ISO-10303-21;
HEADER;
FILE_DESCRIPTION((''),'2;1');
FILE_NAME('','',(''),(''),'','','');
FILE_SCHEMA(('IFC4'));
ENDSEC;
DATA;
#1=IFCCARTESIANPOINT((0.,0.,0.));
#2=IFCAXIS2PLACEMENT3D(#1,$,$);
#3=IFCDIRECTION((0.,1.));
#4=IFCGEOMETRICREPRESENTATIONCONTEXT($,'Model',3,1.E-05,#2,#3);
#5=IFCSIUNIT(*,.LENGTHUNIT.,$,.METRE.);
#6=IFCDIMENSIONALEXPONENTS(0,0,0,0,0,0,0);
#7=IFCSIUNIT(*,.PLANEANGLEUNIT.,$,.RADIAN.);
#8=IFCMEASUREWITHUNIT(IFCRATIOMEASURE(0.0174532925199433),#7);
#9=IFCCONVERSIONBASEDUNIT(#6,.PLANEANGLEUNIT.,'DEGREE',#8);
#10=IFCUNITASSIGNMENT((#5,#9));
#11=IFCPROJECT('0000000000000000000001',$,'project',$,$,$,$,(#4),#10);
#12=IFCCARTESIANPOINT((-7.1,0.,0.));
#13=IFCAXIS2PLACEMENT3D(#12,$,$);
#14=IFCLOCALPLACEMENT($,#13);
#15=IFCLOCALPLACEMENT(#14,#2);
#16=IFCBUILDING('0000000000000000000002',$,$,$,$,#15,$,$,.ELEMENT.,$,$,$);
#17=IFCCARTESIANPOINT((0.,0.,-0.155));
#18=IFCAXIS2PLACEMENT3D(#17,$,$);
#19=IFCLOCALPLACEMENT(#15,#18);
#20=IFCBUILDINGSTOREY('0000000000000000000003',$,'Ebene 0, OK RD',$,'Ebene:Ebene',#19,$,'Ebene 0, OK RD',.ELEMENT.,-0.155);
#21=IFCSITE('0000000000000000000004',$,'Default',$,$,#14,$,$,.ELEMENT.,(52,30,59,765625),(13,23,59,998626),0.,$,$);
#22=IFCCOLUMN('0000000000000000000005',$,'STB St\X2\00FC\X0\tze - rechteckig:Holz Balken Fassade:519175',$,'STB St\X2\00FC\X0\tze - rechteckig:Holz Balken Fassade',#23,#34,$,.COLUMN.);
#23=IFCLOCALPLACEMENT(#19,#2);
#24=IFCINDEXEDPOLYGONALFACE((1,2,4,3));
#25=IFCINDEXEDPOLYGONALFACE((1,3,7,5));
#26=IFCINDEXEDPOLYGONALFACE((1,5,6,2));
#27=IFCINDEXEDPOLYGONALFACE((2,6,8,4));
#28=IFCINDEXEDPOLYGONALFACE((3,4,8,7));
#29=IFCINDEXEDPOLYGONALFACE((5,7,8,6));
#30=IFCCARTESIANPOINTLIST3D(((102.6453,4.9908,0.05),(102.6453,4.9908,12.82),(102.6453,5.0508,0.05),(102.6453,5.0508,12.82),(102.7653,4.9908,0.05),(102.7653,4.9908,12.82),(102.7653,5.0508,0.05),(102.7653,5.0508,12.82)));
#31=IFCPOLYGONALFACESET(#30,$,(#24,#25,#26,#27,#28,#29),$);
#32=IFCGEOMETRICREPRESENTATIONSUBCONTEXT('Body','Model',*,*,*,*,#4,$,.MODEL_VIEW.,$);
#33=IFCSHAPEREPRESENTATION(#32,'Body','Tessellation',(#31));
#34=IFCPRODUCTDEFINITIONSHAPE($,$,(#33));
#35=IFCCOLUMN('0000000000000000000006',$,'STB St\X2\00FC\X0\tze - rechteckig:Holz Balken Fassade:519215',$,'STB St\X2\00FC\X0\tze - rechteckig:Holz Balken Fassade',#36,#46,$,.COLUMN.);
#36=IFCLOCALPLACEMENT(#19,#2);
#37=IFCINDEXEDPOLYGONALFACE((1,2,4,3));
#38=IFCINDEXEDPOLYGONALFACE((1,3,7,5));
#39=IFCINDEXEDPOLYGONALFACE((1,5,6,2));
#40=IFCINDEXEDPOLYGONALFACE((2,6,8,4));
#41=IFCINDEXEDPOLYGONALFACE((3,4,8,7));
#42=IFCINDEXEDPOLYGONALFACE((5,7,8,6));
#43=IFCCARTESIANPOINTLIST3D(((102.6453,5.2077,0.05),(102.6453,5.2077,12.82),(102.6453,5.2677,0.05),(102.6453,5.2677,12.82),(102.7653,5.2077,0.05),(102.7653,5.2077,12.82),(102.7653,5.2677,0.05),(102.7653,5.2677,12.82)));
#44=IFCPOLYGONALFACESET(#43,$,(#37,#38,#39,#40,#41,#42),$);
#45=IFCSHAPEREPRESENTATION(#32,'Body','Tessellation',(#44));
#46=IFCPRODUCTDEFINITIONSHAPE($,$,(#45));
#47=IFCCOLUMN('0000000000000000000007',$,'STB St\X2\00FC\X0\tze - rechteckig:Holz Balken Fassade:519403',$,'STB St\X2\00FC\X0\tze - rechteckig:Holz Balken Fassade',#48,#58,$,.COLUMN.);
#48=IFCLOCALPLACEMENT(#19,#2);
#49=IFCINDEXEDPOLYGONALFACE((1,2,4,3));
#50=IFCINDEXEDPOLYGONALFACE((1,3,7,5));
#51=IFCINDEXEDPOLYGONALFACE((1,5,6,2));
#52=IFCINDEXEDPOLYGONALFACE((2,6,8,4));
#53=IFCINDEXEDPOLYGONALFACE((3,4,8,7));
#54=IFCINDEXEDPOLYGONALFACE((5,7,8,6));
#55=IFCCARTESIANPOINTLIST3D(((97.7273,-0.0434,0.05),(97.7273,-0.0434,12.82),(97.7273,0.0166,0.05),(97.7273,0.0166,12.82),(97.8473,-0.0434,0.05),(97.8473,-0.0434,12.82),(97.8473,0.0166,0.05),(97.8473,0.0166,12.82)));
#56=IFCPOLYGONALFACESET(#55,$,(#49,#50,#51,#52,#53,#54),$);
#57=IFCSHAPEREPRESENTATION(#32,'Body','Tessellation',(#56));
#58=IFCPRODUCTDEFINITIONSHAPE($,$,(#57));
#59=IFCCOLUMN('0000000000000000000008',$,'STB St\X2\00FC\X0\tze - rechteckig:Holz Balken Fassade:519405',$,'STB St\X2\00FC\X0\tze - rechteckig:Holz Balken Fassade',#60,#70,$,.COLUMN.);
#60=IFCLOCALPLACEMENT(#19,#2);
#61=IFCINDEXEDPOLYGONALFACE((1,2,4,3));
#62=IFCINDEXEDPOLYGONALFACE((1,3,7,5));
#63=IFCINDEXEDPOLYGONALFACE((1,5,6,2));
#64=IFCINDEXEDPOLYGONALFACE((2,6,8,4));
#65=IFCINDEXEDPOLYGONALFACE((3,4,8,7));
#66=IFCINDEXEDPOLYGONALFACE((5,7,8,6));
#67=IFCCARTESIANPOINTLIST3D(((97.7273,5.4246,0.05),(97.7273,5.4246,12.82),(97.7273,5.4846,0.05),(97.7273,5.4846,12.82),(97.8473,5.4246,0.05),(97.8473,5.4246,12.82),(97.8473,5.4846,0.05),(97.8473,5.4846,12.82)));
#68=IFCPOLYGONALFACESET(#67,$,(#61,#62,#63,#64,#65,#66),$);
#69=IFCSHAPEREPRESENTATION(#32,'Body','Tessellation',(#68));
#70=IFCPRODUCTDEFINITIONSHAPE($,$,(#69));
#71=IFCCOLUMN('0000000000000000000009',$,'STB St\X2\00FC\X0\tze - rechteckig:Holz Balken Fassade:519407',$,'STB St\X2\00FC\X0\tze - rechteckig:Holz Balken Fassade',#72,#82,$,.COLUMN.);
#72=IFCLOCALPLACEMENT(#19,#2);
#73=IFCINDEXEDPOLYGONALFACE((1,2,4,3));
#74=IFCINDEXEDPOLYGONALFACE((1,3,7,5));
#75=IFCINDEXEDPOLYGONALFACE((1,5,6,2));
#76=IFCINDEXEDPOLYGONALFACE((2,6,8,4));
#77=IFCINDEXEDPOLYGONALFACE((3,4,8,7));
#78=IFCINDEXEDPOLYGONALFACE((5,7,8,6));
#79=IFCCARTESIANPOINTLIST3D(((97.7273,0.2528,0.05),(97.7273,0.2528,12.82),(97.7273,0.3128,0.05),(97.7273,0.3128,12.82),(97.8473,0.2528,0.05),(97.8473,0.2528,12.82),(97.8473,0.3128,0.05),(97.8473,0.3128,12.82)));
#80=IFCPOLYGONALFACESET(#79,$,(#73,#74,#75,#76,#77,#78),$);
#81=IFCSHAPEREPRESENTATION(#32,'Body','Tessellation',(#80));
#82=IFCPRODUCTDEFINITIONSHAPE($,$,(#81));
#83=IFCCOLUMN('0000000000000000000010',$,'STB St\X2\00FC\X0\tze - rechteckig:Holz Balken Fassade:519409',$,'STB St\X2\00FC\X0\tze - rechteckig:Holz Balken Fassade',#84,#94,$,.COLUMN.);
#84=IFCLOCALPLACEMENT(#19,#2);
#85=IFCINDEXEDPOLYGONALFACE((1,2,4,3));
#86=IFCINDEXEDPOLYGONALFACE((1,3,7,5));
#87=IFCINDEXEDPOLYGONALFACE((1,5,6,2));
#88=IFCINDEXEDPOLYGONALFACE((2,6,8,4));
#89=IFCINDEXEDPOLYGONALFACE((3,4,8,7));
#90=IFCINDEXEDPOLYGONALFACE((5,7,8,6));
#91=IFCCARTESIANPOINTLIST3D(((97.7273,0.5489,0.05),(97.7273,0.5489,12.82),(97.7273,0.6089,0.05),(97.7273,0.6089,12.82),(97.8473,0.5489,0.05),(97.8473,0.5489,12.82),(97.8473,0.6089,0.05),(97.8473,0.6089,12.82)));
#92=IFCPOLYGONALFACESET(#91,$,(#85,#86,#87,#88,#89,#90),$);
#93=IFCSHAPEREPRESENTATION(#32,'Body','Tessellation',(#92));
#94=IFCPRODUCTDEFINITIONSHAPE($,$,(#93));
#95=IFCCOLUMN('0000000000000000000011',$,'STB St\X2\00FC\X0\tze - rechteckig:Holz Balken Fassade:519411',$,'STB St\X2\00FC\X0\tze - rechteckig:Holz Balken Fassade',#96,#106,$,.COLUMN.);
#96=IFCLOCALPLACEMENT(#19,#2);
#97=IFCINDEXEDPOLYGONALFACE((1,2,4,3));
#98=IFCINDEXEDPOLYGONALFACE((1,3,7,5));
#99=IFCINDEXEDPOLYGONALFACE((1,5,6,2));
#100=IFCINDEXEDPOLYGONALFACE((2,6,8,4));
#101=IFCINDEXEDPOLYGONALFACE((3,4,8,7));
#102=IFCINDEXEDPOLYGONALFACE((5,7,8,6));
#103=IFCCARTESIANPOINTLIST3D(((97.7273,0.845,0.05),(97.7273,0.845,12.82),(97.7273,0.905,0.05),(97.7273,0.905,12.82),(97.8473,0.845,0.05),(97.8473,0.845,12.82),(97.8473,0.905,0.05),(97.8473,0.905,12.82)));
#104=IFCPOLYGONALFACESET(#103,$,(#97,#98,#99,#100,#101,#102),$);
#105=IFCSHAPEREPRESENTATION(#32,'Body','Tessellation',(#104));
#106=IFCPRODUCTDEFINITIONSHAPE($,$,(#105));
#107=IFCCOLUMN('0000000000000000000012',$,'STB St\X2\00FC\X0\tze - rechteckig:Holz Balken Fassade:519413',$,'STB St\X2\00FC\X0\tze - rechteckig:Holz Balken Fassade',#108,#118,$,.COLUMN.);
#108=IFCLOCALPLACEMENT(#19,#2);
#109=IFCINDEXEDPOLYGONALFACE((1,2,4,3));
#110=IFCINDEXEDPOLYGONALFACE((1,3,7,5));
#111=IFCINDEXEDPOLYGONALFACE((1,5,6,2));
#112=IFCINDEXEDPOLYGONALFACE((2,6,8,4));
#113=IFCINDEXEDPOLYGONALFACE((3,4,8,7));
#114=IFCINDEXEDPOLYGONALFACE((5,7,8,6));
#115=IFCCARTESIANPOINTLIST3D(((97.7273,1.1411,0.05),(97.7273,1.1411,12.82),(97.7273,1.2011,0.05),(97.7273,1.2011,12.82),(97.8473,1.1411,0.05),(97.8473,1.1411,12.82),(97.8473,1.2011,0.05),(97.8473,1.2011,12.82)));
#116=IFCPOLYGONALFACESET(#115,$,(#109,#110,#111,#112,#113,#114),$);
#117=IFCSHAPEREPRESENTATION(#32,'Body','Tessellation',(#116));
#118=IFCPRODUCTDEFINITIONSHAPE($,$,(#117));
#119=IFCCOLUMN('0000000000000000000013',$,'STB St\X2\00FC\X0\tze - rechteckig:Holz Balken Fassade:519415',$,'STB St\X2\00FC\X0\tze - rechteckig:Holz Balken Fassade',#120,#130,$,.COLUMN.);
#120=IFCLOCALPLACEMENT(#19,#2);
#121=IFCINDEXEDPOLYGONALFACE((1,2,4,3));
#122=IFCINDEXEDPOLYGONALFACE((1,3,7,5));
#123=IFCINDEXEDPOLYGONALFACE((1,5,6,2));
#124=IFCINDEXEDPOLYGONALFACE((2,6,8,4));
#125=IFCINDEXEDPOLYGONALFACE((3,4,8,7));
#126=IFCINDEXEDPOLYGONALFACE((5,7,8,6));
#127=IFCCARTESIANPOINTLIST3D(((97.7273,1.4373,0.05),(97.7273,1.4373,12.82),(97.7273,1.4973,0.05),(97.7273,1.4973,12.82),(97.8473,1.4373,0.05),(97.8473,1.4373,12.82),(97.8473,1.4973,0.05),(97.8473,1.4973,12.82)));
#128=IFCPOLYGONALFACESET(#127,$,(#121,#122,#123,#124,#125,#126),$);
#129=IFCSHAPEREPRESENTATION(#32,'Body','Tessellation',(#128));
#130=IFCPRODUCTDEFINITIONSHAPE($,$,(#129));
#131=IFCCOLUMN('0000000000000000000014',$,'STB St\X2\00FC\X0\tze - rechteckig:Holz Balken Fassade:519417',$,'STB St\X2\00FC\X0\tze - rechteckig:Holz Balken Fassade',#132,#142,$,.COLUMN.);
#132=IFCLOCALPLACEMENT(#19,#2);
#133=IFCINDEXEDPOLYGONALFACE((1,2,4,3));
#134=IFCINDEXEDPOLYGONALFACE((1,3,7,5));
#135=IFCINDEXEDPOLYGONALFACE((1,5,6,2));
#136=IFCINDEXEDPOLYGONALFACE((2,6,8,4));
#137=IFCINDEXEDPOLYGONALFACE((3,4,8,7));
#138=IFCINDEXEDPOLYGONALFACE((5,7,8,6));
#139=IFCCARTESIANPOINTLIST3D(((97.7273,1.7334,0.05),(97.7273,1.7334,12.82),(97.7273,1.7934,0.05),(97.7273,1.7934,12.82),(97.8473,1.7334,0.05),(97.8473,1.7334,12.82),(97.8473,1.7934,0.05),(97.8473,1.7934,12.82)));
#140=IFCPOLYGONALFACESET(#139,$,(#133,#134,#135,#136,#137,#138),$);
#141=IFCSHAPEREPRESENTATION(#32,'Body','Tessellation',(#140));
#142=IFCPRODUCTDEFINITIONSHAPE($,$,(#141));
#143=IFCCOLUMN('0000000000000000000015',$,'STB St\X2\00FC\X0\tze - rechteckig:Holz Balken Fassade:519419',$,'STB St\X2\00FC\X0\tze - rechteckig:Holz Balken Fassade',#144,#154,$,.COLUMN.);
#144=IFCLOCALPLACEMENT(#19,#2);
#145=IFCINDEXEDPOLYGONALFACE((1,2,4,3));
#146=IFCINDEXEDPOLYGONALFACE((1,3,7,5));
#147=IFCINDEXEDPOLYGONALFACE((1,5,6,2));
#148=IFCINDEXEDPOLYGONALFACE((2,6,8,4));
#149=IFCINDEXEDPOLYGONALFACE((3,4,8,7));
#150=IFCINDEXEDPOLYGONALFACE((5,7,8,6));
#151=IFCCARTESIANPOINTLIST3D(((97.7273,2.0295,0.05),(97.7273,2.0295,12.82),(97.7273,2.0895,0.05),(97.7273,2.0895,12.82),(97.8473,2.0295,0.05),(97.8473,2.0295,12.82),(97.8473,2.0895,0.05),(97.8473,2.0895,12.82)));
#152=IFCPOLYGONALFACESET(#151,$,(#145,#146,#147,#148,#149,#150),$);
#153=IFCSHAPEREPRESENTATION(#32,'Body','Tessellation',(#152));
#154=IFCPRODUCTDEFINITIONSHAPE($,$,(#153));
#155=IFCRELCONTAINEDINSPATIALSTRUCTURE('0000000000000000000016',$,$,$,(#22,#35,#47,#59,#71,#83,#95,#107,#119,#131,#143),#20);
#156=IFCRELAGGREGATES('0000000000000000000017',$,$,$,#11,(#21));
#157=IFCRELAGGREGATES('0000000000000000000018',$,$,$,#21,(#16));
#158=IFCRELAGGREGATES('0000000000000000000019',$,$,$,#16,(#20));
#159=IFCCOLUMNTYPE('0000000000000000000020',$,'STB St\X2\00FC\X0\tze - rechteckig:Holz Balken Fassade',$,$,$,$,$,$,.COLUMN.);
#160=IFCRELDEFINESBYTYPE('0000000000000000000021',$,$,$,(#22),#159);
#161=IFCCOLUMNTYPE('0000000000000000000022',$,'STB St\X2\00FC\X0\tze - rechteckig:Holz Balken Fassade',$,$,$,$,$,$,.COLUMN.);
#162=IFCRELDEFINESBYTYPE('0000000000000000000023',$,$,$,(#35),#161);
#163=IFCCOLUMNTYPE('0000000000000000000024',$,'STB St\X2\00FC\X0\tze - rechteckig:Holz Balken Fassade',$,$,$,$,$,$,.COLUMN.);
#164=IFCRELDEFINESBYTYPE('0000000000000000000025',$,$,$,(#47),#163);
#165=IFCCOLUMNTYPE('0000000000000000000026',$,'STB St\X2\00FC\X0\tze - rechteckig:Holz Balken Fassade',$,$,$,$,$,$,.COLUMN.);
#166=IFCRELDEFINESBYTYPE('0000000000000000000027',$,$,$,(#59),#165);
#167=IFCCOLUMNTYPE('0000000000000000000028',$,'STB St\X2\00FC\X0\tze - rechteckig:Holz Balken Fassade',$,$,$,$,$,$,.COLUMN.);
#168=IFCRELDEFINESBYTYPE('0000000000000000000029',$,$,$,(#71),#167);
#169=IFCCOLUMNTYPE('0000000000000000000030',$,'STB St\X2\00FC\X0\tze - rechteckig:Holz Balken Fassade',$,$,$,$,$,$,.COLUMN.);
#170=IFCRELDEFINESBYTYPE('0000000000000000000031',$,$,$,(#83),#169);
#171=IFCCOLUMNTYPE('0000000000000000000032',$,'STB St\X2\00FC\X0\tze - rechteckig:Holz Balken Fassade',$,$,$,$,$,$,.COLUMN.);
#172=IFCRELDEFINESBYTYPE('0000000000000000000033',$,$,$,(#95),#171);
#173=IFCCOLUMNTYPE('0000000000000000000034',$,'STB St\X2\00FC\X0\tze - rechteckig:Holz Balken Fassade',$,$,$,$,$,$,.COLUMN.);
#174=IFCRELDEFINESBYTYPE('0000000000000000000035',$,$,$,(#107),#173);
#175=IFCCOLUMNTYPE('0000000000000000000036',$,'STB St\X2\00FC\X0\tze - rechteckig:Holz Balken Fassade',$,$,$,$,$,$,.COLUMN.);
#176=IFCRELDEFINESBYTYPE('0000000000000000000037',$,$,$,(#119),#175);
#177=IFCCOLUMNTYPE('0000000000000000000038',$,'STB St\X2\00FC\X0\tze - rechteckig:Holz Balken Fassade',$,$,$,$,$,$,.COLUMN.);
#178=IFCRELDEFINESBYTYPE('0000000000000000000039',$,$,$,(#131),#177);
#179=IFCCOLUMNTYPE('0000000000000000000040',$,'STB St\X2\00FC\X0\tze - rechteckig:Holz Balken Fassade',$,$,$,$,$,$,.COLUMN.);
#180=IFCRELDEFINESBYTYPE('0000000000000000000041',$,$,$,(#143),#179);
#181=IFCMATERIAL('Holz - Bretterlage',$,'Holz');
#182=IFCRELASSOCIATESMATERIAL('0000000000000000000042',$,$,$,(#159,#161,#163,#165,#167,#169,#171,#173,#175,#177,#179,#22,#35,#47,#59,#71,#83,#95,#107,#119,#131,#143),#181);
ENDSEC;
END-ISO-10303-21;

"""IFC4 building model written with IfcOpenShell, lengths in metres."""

from ifc_helpers import new_model, entity, si_unit, converted_unit, direction, frame, frame_2d, origin, origin_2d_with_axis, place, context, subcontext, project, spatial, rectangle, extrude, source, transform, mapped, material, material_profile, profile_set, profile_usage, type_object, type_shapes, element, save


model = new_model("IFC4")

# Units and contexts
model_context = context("Model", 3, precision=1e-05, world=origin(), true_north=direction((0.0, 1.0)))
body_context = subcontext(model_context, "Body", "Model", "MODEL_VIEW")
ifc_project = project(units=[si_unit("LENGTHUNIT", "METRE"), converted_unit("PLANEANGLEUNIT", "DEGREE", entity("IfcRatioMeasure", 0.0174532925199433), si_unit("PLANEANGLEUNIT", "RADIAN"), dimensions=[0, 0, 0, 0, 0, 0, 0])], contexts=[model_context])

# Site, building, storey
site_placement = place(None, frame((-7.1, 0.0, 0.0)))
site = spatial("IfcSite", under=ifc_project, at=site_placement, Name="Default", CompositionType="ELEMENT", RefLatitude=(52, 30, 59, 765625), RefLongitude=(13, 23, 59, 998626), RefElevation=0.0)
building_placement = place(site_placement, origin())
building = spatial("IfcBuilding", under=site, at=building_placement, CompositionType="ELEMENT")
storey_placement = place(building_placement, frame((0.0, 0.0, -0.155)))
storey = spatial("IfcBuildingStorey", under=building, at=storey_placement, Name="Ebene 0, OK RD", ObjectType="Ebene:Ebene", LongName="Ebene 0, OK RD", CompositionType="ELEMENT", Elevation=-0.155)

# Columns
ifc_material_1 = material(Name="Holz - Bretterlage", Category="Holz")
ifc_material_profile = material_profile(ifc_material_1, rectangle(XDim=0.12, YDim=0.06, at=frame_2d((0.0, 0.0), x_axis=(1.0, 0.0))), Name="Holz Balken Fassade")
ifc_profile_set = profile_set([ifc_material_profile], Name="Holz Balken Fassade")
ifc_profile_usage_1 = profile_usage(ifc_profile_set)
column_type_1 = type_object("IfcColumnType", Name="STB Stütze - rechteckig:Holz Balken Fassade", PredefinedType="COLUMN", material=ifc_profile_set)
shared_shape_1 = source(origin(), body_context, "Body", "SweptSolid", [
    extrude(rectangle(XDim=0.06, YDim=0.12, at=origin_2d_with_axis()), frame((102.7053, 5.0208, -0.105), z_axis=(0.0, 0.0, 1.0), x_axis=(0.0, -1.0, 0.0)), (0.0, 0.0, 1.0), 12.77),
])
type_shapes(column_type_1, [shared_shape_1])
column_1_placement = place(storey_placement, frame((0.0, 0.0, 0.155)))
element("IfcColumn", 1, at=column_1_placement, inside=storey, type_object=column_type_1, material=ifc_profile_usage_1, Name="STB Stütze - rechteckig:Holz Balken Fassade:519175", ObjectType="STB Stütze - rechteckig:Holz Balken Fassade", PredefinedType="COLUMN", context=body_context, shape_type="MappedRepresentation", body=[
    mapped(shared_shape_1, transform((0.0, 0.0, 0.0), scale=1.0)),
])
ifc_profile_usage_2 = profile_usage(ifc_profile_set)
column_type_2 = type_object("IfcColumnType", Name="STB Stütze - rechteckig:Holz Balken Fassade", PredefinedType="COLUMN", material=ifc_profile_set)
shared_shape_2 = source(origin(), body_context, "Body", "SweptSolid", [
    extrude(rectangle(XDim=0.06, YDim=0.12, at=origin_2d_with_axis()), frame((102.7053, 5.2377, -0.105), z_axis=(0.0, 0.0, 1.0), x_axis=(0.0, -1.0, 0.0)), (0.0, 0.0, 1.0), 12.77),
])
type_shapes(column_type_2, [shared_shape_2])
column_2_placement = place(storey_placement, frame((0.0, 0.0, 0.155)))
element("IfcColumn", 2, at=column_2_placement, inside=storey, type_object=column_type_2, material=ifc_profile_usage_2, Name="STB Stütze - rechteckig:Holz Balken Fassade:519215", ObjectType="STB Stütze - rechteckig:Holz Balken Fassade", PredefinedType="COLUMN", context=body_context, shape_type="MappedRepresentation", body=[
    mapped(shared_shape_2, transform((0.0, 0.0, 0.0), scale=1.0)),
])
ifc_profile_usage_3 = profile_usage(ifc_profile_set)
column_type_3 = type_object("IfcColumnType", Name="STB Stütze - rechteckig:Holz Balken Fassade", PredefinedType="COLUMN", material=ifc_profile_set)
shared_shape_3 = source(origin(), body_context, "Body", "SweptSolid", [
    extrude(rectangle(XDim=0.06, YDim=0.12, at=frame_2d((0.0, 0.0), x_axis=(1.0, 0.0))), frame((97.7873, -0.0134, -0.105), z_axis=(0.0, 0.0, 1.0), x_axis=(0.0, -1.0, 0.0)), (0.0, 0.0, 1.0), 12.77),
])
type_shapes(column_type_3, [shared_shape_3])
column_3_placement = place(storey_placement, frame((0.0, 0.0, 0.155)))
element("IfcColumn", 3, at=column_3_placement, inside=storey, type_object=column_type_3, material=ifc_profile_usage_3, Name="STB Stütze - rechteckig:Holz Balken Fassade:519403", ObjectType="STB Stütze - rechteckig:Holz Balken Fassade", PredefinedType="COLUMN", context=body_context, shape_type="MappedRepresentation", body=[
    mapped(shared_shape_3, transform((0.0, 0.0, 0.0), scale=1.0)),
])
ifc_profile_usage_4 = profile_usage(ifc_profile_set)
column_type_4 = type_object("IfcColumnType", Name="STB Stütze - rechteckig:Holz Balken Fassade", PredefinedType="COLUMN", material=ifc_profile_set)
shared_shape_4 = source(origin(), body_context, "Body", "SweptSolid", [
    extrude(rectangle(XDim=0.06, YDim=0.12, at=origin_2d_with_axis()), frame((97.7873, 5.4546, -0.105), z_axis=(0.0, 0.0, 1.0), x_axis=(0.0, -1.0, 0.0)), (0.0, 0.0, 1.0), 12.77),
])
type_shapes(column_type_4, [shared_shape_4])
column_4_placement = place(storey_placement, frame((0.0, 0.0, 0.155)))
element("IfcColumn", 4, at=column_4_placement, inside=storey, type_object=column_type_4, material=ifc_profile_usage_4, Name="STB Stütze - rechteckig:Holz Balken Fassade:519405", ObjectType="STB Stütze - rechteckig:Holz Balken Fassade", PredefinedType="COLUMN", context=body_context, shape_type="MappedRepresentation", body=[
    mapped(shared_shape_4, transform((0.0, 0.0, 0.0), scale=1.0)),
])
ifc_profile_usage_5 = profile_usage(ifc_profile_set)
column_type_5 = type_object("IfcColumnType", Name="STB Stütze - rechteckig:Holz Balken Fassade", PredefinedType="COLUMN", material=ifc_profile_set)
shared_shape_5 = source(origin(), body_context, "Body", "SweptSolid", [
    extrude(rectangle(XDim=0.06, YDim=0.12, at=frame_2d((0.0, 0.0), x_axis=(1.0, 0.0))), frame((97.7873, 0.2828, -0.105), z_axis=(0.0, 0.0, 1.0), x_axis=(0.0, -1.0, 0.0)), (0.0, 0.0, 1.0), 12.77),
])
type_shapes(column_type_5, [shared_shape_5])
column_5_placement = place(storey_placement, frame((0.0, 0.0, 0.155)))
element("IfcColumn", 5, at=column_5_placement, inside=storey, type_object=column_type_5, material=ifc_profile_usage_5, Name="STB Stütze - rechteckig:Holz Balken Fassade:519407", ObjectType="STB Stütze - rechteckig:Holz Balken Fassade", PredefinedType="COLUMN", context=body_context, shape_type="MappedRepresentation", body=[
    mapped(shared_shape_5, transform((0.0, 0.0, 0.0), scale=1.0)),
])
ifc_profile_usage_6 = profile_usage(ifc_profile_set)
column_type_6 = type_object("IfcColumnType", Name="STB Stütze - rechteckig:Holz Balken Fassade", PredefinedType="COLUMN", material=ifc_profile_set)
shared_shape_6 = source(origin(), body_context, "Body", "SweptSolid", [
    extrude(rectangle(XDim=0.06, YDim=0.12, at=frame_2d((0.0, 0.0), x_axis=(1.0, 0.0))), frame((97.7873, 0.5789, -0.105), z_axis=(0.0, 0.0, 1.0), x_axis=(0.0, -1.0, 0.0)), (0.0, 0.0, 1.0), 12.77),
])
type_shapes(column_type_6, [shared_shape_6])
column_6_placement = place(storey_placement, frame((0.0, 0.0, 0.155)))
element("IfcColumn", 6, at=column_6_placement, inside=storey, type_object=column_type_6, material=ifc_profile_usage_6, Name="STB Stütze - rechteckig:Holz Balken Fassade:519409", ObjectType="STB Stütze - rechteckig:Holz Balken Fassade", PredefinedType="COLUMN", context=body_context, shape_type="MappedRepresentation", body=[
    mapped(shared_shape_6, transform((0.0, 0.0, 0.0), scale=1.0)),
])
ifc_profile_usage_7 = profile_usage(ifc_profile_set)
column_type_7 = type_object("IfcColumnType", Name="STB Stütze - rechteckig:Holz Balken Fassade", PredefinedType="COLUMN", material=ifc_profile_set)
shared_shape_7 = source(origin(), body_context, "Body", "SweptSolid", [
    extrude(rectangle(XDim=0.06, YDim=0.12, at=origin_2d_with_axis()), frame((97.7873, 0.875, -0.105), z_axis=(0.0, 0.0, 1.0), x_axis=(0.0, -1.0, 0.0)), (0.0, 0.0, 1.0), 12.77),
])
type_shapes(column_type_7, [shared_shape_7])
column_7_placement = place(storey_placement, frame((0.0, 0.0, 0.155)))
element("IfcColumn", 7, at=column_7_placement, inside=storey, type_object=column_type_7, material=ifc_profile_usage_7, Name="STB Stütze - rechteckig:Holz Balken Fassade:519411", ObjectType="STB Stütze - rechteckig:Holz Balken Fassade", PredefinedType="COLUMN", context=body_context, shape_type="MappedRepresentation", body=[
    mapped(shared_shape_7, transform((0.0, 0.0, 0.0), scale=1.0)),
])
ifc_profile_usage_8 = profile_usage(ifc_profile_set)
column_type_8 = type_object("IfcColumnType", Name="STB Stütze - rechteckig:Holz Balken Fassade", PredefinedType="COLUMN", material=ifc_profile_set)
shared_shape_8 = source(origin(), body_context, "Body", "SweptSolid", [
    extrude(rectangle(XDim=0.06, YDim=0.12, at=frame_2d((0.0, 0.0), x_axis=(1.0, 0.0))), frame((97.7873, 1.1711, -0.105), z_axis=(0.0, 0.0, 1.0), x_axis=(0.0, -1.0, 0.0)), (0.0, 0.0, 1.0), 12.77),
])
type_shapes(column_type_8, [shared_shape_8])
column_8_placement = place(storey_placement, frame((0.0, 0.0, 0.155)))
element("IfcColumn", 8, at=column_8_placement, inside=storey, type_object=column_type_8, material=ifc_profile_usage_8, Name="STB Stütze - rechteckig:Holz Balken Fassade:519413", ObjectType="STB Stütze - rechteckig:Holz Balken Fassade", PredefinedType="COLUMN", context=body_context, shape_type="MappedRepresentation", body=[
    mapped(shared_shape_8, transform((0.0, 0.0, 0.0), scale=1.0)),
])
ifc_profile_usage_9 = profile_usage(ifc_profile_set)
column_type_9 = type_object("IfcColumnType", Name="STB Stütze - rechteckig:Holz Balken Fassade", PredefinedType="COLUMN", material=ifc_profile_set)
shared_shape_9 = source(origin(), body_context, "Body", "SweptSolid", [
    extrude(rectangle(XDim=0.06, YDim=0.12, at=frame_2d((0.0, 0.0), x_axis=(1.0, 0.0))), frame((97.7873, 1.4673, -0.105), z_axis=(0.0, 0.0, 1.0), x_axis=(0.0, -1.0, 0.0)), (0.0, 0.0, 1.0), 12.77),
])
type_shapes(column_type_9, [shared_shape_9])
column_9_placement = place(storey_placement, frame((0.0, 0.0, 0.155)))
element("IfcColumn", 9, at=column_9_placement, inside=storey, type_object=column_type_9, material=ifc_profile_usage_9, Name="STB Stütze - rechteckig:Holz Balken Fassade:519415", ObjectType="STB Stütze - rechteckig:Holz Balken Fassade", PredefinedType="COLUMN", context=body_context, shape_type="MappedRepresentation", body=[
    mapped(shared_shape_9, transform((0.0, 0.0, 0.0), scale=1.0)),
])
ifc_profile_usage_10 = profile_usage(ifc_profile_set)
column_type_10 = type_object("IfcColumnType", Name="STB Stütze - rechteckig:Holz Balken Fassade", PredefinedType="COLUMN", material=ifc_profile_set)
shared_shape_10 = source(origin(), body_context, "Body", "SweptSolid", [
    extrude(rectangle(XDim=0.06, YDim=0.12, at=frame_2d((0.0, 0.0), x_axis=(1.0, 0.0))), frame((97.7873, 1.7634, -0.105), z_axis=(0.0, 0.0, 1.0), x_axis=(0.0, -1.0, 0.0)), (0.0, 0.0, 1.0), 12.77),
])
type_shapes(column_type_10, [shared_shape_10])
column_10_placement = place(storey_placement, frame((0.0, 0.0, 0.155)))
element("IfcColumn", 10, at=column_10_placement, inside=storey, type_object=column_type_10, material=ifc_profile_usage_10, Name="STB Stütze - rechteckig:Holz Balken Fassade:519417", ObjectType="STB Stütze - rechteckig:Holz Balken Fassade", PredefinedType="COLUMN", context=body_context, shape_type="MappedRepresentation", body=[
    mapped(shared_shape_10, transform((0.0, 0.0, 0.0), scale=1.0)),
])
ifc_profile_usage_11 = profile_usage(ifc_profile_set)
column_type_11 = type_object("IfcColumnType", Name="STB Stütze - rechteckig:Holz Balken Fassade", PredefinedType="COLUMN", material=ifc_profile_set)
shared_shape_11 = source(origin(), body_context, "Body", "SweptSolid", [
    extrude(rectangle(XDim=0.06, YDim=0.12, at=frame_2d((0.0, 0.0), x_axis=(1.0, 0.0))), frame((97.7873, 2.0595, -0.105), z_axis=(0.0, 0.0, 1.0), x_axis=(0.0, -1.0, 0.0)), (0.0, 0.0, 1.0), 12.77),
])
type_shapes(column_type_11, [shared_shape_11])
column_11_placement = place(storey_placement, frame((0.0, 0.0, 0.155)))
element("IfcColumn", 11, at=column_11_placement, inside=storey, type_object=column_type_11, material=ifc_profile_usage_11, Name="STB Stütze - rechteckig:Holz Balken Fassade:519419", ObjectType="STB Stütze - rechteckig:Holz Balken Fassade", PredefinedType="COLUMN", context=body_context, shape_type="MappedRepresentation", body=[
    mapped(shared_shape_11, transform((0.0, 0.0, 0.0), scale=1.0)),
])

save(model, "model.ifc")
